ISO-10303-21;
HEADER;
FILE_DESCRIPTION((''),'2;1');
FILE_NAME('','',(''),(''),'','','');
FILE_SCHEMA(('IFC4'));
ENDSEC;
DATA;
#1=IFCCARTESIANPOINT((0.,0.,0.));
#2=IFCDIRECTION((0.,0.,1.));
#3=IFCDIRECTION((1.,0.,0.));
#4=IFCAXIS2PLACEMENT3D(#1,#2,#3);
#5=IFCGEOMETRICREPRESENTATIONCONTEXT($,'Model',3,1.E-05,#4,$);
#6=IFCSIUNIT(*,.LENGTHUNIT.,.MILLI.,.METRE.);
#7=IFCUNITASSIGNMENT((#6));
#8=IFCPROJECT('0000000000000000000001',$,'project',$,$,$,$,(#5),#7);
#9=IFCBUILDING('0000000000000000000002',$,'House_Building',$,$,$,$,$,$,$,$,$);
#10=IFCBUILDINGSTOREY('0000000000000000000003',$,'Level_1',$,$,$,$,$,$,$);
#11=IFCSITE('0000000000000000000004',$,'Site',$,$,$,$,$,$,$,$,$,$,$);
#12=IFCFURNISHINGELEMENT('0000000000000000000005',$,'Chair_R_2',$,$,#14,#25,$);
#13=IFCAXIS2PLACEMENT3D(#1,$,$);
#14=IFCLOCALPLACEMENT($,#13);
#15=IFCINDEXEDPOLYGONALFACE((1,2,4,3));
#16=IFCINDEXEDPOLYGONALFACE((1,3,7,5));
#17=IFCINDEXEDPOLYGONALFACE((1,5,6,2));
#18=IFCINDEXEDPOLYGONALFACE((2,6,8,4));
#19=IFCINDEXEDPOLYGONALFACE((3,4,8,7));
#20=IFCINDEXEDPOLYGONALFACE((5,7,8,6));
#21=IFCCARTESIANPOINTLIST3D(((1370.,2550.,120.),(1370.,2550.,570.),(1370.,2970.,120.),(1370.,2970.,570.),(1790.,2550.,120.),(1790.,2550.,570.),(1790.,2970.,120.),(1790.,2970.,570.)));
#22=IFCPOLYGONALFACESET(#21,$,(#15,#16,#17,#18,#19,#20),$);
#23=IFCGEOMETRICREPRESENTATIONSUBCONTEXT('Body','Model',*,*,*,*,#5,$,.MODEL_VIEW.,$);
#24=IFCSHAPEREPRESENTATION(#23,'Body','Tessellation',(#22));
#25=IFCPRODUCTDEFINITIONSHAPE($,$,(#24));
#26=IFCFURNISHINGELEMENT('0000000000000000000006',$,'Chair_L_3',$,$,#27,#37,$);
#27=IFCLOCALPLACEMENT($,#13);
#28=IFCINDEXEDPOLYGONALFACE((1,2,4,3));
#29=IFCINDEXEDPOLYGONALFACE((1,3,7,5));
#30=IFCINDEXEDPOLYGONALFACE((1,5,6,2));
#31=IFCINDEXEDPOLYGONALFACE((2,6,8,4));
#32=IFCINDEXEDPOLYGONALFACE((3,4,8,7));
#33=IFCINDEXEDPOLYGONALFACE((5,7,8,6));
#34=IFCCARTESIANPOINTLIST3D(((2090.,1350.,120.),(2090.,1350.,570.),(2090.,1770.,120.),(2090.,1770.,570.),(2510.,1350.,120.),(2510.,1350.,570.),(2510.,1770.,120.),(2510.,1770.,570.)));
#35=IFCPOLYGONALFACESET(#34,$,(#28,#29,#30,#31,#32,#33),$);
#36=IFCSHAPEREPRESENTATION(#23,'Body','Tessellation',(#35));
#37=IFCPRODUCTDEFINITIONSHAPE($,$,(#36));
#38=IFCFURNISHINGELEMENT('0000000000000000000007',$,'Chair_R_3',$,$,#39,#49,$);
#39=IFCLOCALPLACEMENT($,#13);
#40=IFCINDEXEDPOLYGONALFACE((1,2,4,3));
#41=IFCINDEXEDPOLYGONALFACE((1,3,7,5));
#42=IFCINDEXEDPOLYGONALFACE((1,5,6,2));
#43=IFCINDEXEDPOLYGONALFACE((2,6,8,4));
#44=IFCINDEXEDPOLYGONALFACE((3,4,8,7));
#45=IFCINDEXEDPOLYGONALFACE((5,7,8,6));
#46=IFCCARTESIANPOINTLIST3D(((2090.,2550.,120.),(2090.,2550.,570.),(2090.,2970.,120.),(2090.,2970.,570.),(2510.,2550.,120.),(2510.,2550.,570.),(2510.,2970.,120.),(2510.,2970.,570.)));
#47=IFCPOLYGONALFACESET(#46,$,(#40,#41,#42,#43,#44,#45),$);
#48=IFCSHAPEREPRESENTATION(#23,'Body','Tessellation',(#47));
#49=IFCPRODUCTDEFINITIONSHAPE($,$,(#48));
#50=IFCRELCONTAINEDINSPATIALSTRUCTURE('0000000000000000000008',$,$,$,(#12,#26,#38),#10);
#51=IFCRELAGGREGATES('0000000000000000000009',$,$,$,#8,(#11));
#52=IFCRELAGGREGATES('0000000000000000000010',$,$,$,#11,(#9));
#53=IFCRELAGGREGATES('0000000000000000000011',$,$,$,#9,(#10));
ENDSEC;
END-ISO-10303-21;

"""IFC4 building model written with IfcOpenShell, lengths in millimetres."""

from ifc_helpers import new_model, si_unit, frame, origin_with_axes, context, subcontext, project, spatial, polyline, outline, extrude, element, save


model = new_model("IFC4")

# Units and contexts
model_context = context("Model", 3, precision=1e-05, world=origin_with_axes())
body_context = subcontext(model_context, "Body", "Model", "MODEL_VIEW")
ifc_project = project(units=[si_unit("LENGTHUNIT", "METRE", prefix="MILLI")], contexts=[model_context])

# Site, building, storey
site = spatial("IfcSite", under=ifc_project, Name="Site")
building = spatial("IfcBuilding", under=site, Name="House_Building")
storey = spatial("IfcBuildingStorey", under=building, Name="Level_1")

# Furnishing elements
element("IfcFurnishingElement", 1, inside=storey, Name="Chair_R_2", context=body_context, shape_type="SweptSolid", body=[
    extrude(outline(polyline([(1370.0, 2550.0), (1790.0, 2550.0), (1790.0, 2970.0), (1370.0, 2970.0), (1370.0, 2550.0)])), frame((0.0, 0.0, 120.0), z_axis=(0.0, 0.0, 1.0), x_axis=(1.0, 0.0, 0.0)), (0.0, 0.0, 1.0), 450.0),
])
element("IfcFurnishingElement", 2, inside=storey, Name="Chair_L_3", context=body_context, shape_type="SweptSolid", body=[
    extrude(outline(polyline([(2090.0, 1350.0), (2510.0, 1350.0), (2510.0, 1770.0), (2090.0, 1770.0), (2090.0, 1350.0)])), frame((0.0, 0.0, 120.0), z_axis=(0.0, 0.0, 1.0), x_axis=(1.0, 0.0, 0.0)), (0.0, 0.0, 1.0), 450.0),
])
element("IfcFurnishingElement", 3, inside=storey, Name="Chair_R_3", context=body_context, shape_type="SweptSolid", body=[
    extrude(outline(polyline([(2090.0, 2550.0), (2510.0, 2550.0), (2510.0, 2970.0), (2090.0, 2970.0), (2090.0, 2550.0)])), frame((0.0, 0.0, 120.0), z_axis=(0.0, 0.0, 1.0), x_axis=(1.0, 0.0, 0.0)), (0.0, 0.0, 1.0), 450.0),
])

save(model, "model.ifc")
